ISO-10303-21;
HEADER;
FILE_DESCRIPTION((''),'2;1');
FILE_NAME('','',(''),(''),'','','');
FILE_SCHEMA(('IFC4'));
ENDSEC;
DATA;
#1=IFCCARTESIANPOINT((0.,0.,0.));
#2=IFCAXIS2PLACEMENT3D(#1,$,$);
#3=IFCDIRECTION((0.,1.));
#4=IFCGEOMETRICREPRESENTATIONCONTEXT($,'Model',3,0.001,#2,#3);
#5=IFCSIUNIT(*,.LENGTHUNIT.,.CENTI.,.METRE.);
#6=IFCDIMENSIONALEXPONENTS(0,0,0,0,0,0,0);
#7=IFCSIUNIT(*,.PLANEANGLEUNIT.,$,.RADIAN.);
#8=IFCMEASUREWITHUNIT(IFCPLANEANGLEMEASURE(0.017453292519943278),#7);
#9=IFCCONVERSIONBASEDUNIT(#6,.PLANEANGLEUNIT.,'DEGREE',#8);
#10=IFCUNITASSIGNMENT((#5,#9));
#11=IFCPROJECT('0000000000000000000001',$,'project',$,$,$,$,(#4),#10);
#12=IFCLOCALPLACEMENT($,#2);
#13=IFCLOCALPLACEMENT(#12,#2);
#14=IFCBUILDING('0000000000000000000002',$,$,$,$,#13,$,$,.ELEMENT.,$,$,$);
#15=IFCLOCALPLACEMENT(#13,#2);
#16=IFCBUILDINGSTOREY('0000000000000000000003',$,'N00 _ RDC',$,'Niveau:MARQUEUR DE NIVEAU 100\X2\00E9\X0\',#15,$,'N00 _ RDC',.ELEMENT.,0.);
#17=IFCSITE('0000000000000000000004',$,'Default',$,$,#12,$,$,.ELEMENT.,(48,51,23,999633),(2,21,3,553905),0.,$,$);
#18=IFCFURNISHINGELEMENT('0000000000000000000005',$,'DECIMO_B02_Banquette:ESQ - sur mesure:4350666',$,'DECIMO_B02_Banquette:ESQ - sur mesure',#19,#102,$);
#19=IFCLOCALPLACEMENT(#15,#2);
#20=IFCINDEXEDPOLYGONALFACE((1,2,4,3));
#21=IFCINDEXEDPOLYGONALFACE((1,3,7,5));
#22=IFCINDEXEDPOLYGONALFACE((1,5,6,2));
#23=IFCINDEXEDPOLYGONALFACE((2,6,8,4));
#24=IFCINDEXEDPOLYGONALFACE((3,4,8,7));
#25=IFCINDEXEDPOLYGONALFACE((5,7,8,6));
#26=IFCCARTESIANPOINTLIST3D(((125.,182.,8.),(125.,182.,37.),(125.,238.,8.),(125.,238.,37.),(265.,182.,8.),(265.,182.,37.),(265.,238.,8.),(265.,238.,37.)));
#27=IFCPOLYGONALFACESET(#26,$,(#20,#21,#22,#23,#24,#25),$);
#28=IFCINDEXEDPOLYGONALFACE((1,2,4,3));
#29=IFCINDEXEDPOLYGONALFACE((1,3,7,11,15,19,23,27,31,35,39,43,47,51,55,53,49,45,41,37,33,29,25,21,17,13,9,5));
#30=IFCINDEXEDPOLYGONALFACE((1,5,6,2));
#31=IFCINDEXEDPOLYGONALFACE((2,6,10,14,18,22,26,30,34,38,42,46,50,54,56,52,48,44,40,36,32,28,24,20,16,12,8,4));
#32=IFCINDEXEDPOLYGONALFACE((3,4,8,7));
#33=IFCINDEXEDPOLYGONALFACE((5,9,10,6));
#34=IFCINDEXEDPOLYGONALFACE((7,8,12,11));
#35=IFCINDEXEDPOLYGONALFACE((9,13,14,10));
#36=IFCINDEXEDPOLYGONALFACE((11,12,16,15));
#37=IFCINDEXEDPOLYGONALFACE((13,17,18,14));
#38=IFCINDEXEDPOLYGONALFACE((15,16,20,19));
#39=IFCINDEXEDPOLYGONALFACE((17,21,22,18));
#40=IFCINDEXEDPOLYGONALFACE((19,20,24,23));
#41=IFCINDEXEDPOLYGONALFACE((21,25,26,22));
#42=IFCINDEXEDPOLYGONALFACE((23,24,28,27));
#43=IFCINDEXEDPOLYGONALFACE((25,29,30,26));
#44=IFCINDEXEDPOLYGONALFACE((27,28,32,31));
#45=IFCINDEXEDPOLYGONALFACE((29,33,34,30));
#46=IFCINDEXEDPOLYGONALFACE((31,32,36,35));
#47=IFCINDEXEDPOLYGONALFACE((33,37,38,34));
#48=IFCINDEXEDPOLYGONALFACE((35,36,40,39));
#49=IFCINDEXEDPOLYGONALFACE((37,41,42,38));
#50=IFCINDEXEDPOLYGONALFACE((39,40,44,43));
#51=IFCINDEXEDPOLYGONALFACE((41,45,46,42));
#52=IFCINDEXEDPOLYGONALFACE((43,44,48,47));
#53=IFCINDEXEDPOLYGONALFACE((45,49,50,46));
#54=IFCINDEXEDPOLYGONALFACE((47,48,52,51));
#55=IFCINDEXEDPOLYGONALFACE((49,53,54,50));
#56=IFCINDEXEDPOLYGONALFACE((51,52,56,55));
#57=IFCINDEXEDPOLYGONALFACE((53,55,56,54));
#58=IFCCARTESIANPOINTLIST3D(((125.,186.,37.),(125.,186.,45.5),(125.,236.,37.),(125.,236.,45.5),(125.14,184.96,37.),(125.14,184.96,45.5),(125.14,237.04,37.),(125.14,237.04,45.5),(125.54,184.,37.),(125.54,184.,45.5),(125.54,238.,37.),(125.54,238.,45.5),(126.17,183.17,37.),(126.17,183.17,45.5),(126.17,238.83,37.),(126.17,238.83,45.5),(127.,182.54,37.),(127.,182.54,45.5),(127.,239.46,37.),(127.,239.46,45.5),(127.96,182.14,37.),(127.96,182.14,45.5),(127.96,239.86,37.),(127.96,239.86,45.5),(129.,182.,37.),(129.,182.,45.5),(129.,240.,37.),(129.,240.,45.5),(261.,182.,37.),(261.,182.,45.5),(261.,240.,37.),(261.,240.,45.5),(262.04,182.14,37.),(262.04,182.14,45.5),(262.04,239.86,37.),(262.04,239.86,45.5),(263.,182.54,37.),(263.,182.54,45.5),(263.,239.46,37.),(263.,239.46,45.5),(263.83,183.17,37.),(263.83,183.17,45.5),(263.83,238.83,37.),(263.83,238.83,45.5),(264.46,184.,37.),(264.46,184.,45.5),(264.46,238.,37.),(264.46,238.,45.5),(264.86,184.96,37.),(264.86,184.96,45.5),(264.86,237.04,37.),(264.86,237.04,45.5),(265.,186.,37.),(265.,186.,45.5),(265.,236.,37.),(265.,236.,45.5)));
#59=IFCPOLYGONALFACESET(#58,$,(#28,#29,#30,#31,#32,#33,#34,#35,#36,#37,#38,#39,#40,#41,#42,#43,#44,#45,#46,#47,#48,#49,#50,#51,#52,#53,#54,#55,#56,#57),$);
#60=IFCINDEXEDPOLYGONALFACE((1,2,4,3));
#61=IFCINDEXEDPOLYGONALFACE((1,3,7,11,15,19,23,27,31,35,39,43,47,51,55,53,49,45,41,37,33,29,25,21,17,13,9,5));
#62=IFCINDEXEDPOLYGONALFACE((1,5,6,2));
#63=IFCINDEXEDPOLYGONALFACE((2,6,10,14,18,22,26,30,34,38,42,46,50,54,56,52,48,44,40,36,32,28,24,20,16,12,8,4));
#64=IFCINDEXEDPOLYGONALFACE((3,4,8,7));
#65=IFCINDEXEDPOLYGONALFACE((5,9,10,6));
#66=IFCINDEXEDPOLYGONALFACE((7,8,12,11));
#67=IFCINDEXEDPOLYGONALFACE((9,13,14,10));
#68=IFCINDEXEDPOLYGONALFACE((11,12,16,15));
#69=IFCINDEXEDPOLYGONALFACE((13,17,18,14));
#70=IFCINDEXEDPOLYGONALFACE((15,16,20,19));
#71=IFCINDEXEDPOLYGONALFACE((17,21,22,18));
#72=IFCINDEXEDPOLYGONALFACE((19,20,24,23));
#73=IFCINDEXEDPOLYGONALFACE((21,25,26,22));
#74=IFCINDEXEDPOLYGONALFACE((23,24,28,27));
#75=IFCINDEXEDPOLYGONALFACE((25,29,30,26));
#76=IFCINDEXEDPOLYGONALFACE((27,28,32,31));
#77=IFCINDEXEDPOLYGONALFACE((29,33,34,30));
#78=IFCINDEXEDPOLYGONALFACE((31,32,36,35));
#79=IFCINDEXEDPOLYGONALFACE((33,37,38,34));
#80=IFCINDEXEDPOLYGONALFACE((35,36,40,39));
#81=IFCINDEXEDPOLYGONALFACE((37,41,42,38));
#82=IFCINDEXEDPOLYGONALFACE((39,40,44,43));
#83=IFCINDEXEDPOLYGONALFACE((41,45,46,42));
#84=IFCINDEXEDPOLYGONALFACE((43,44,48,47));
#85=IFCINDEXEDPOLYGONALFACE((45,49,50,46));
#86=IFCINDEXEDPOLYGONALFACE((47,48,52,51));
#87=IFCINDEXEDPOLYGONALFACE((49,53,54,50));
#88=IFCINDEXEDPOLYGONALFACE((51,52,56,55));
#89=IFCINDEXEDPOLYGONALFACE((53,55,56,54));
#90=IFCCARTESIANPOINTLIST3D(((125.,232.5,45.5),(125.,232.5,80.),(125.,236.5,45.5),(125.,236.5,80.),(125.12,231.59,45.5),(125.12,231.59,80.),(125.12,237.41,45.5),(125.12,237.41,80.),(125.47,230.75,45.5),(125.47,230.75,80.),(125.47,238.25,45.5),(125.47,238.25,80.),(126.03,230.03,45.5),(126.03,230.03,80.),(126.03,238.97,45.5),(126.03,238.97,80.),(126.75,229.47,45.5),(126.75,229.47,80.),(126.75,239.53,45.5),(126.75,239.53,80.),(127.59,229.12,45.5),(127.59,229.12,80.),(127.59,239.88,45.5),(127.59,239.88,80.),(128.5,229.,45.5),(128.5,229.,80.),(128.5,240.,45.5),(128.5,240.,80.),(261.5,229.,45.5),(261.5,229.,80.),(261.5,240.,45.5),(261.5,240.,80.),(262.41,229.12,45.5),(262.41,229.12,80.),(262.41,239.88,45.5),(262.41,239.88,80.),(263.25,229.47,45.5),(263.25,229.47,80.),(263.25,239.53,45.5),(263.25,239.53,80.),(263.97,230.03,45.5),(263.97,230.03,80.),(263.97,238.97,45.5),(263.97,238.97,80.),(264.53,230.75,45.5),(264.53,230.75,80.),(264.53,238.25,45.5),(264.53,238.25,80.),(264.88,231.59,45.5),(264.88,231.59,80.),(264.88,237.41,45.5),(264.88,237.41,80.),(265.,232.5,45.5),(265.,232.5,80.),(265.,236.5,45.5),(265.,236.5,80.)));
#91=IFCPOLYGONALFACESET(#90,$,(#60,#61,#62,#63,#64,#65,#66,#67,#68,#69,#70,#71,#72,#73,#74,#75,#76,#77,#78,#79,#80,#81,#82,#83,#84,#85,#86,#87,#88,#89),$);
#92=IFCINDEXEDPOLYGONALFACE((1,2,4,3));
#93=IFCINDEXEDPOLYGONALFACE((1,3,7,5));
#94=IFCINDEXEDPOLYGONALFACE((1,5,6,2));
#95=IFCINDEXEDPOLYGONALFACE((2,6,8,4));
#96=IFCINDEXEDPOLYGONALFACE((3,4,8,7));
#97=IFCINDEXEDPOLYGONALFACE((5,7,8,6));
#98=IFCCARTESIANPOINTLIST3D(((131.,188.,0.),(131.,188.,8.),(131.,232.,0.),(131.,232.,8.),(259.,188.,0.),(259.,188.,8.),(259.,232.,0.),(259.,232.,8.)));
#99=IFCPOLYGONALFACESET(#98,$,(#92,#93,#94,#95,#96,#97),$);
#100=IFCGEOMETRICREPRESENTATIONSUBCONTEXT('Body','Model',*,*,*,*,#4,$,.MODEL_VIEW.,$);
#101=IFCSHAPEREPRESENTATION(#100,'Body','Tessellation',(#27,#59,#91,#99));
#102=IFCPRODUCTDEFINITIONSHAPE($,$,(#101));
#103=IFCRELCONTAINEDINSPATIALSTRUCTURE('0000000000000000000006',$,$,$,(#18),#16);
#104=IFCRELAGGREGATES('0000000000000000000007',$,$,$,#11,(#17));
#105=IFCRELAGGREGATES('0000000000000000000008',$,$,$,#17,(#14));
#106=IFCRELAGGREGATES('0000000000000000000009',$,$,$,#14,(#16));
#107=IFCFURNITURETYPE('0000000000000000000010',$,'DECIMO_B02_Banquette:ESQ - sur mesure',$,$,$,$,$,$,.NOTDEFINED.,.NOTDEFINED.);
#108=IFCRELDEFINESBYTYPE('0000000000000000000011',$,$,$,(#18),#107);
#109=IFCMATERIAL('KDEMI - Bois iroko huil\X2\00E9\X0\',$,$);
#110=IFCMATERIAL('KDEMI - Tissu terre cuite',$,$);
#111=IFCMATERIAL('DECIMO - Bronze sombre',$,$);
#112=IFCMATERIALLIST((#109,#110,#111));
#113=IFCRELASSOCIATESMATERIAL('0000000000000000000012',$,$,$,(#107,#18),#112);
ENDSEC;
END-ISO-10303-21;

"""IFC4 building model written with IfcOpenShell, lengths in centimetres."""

from ifc_helpers import new_model, entity, si_unit, converted_unit, direction, frame, frame_2d, origin, origin_2d_with_axis, place, context, subcontext, project, spatial, polyline, circle_curve, parameter, trimmed, segment, composite_curve, rectangle, outline, extrude, source, transform, mapped, material, material_list, type_object, type_shapes, element, save


model = new_model("IFC4")

# Units and contexts
model_context = context("Model", 3, precision=0.001, world=origin(), true_north=direction((0.0, 1.0)))
body_context = subcontext(model_context, "Body", "Model", "MODEL_VIEW")
ifc_project = project(units=[si_unit("LENGTHUNIT", "METRE", prefix="CENTI"), converted_unit("PLANEANGLEUNIT", "DEGREE", entity("IfcPlaneAngleMeasure", 0.017453292519943278), si_unit("PLANEANGLEUNIT", "RADIAN"), dimensions=[0, 0, 0, 0, 0, 0, 0])], contexts=[model_context])

# Site, building, storey
site_placement = place(None, origin())
site = spatial("IfcSite", under=ifc_project, at=site_placement, Name="Default", CompositionType="ELEMENT", RefLatitude=(48, 51, 23, 999633), RefLongitude=(2, 21, 3, 553905), RefElevation=0.0)
building_placement = place(site_placement, origin())
building = spatial("IfcBuilding", under=site, at=building_placement, CompositionType="ELEMENT")
storey_placement = place(building_placement, origin())
storey = spatial("IfcBuildingStorey", under=building, at=storey_placement, Name="N00 _ RDC", ObjectType="Niveau:MARQUEUR DE NIVEAU 100é", LongName="N00 _ RDC", CompositionType="ELEMENT", Elevation=0.0)

# Furnishing element
ifc_material_1 = material(Name="KDEMI - Tissu terre cuite")
ifc_material_2 = material(Name="KDEMI - Bois iroko huilé")
ifc_material_3 = material(Name="DECIMO - Bronze sombre")
ifc_material_list_1 = material_list([ifc_material_2, ifc_material_1, ifc_material_3])
furniture_type_1 = type_object("IfcFurnitureType", Name="DECIMO_B02_Banquette:ESQ - sur mesure", AssemblyPlace="NOTDEFINED", material=ifc_material_list_1)
shared_shape_1 = source(origin(), body_context, "Body", "SweptSolid", [
    extrude(rectangle(XDim=140.0, YDim=56.0, at=origin_2d_with_axis()), frame((70.0, 28.0, 8.0)), (0.0, 0.0, 1.0), 29.0),
    extrude(outline(composite_curve([segment(polyline([(-66.0, -29.0), (66.0, -29.0)]), True, "CONTINUOUS"), segment(trimmed(circle_curve(frame_2d((66.0, -25.0), x_axis=(1.0, 0.0)), 4.0), [parameter(270.0)], [parameter(0.0)], True, "PARAMETER"), True, "CONTINUOUS"), segment(polyline([(70.0, -25.0), (70.0, 25.0)]), True, "CONTINUOUS"), segment(trimmed(circle_curve(frame_2d((66.0, 25.0), x_axis=(1.0, 0.0)), 4.0), [parameter(0.0)], [parameter(90.0)], True, "PARAMETER"), True, "CONTINUOUS"), segment(polyline([(66.0, 29.0), (-66.0, 29.0)]), True, "CONTINUOUS"), segment(trimmed(circle_curve(frame_2d((-66.0, 25.0), x_axis=(1.0, 0.0)), 4.0), [parameter(90.0)], [parameter(180.0)], True, "PARAMETER"), True, "CONTINUOUS"), segment(polyline([(-70.0, 25.0), (-70.0, -25.0)]), True, "CONTINUOUS"), segment(trimmed(circle_curve(frame_2d((-66.0, -25.0), x_axis=(1.0, 0.0)), 4.0), [parameter(180.0)], [parameter(270.0)], True, "PARAMETER"), True, "CONTINUOUS")], self_intersect=False)), frame((70.0, 29.0, 37.0)), (0.0, 0.0, 1.0), 8.5),
    extrude(outline(composite_curve([segment(polyline([(-66.5, -5.5), (66.5, -5.5)]), True, "CONTINUOUS"), segment(trimmed(circle_curve(frame_2d((66.5, -2.0), x_axis=(1.0, 0.0)), 3.5), [parameter(270.0)], [parameter(0.0)], True, "PARAMETER"), True, "CONTINUOUS"), segment(polyline([(70.0, -2.0), (70.0, 2.0)]), True, "CONTINUOUS"), segment(trimmed(circle_curve(frame_2d((66.5, 2.0), x_axis=(1.0, 0.0)), 3.5), [parameter(0.0)], [parameter(90.0)], True, "PARAMETER"), True, "CONTINUOUS"), segment(polyline([(66.5, 5.5), (-66.5, 5.5)]), True, "CONTINUOUS"), segment(trimmed(circle_curve(frame_2d((-66.5, 2.0), x_axis=(1.0, 0.0)), 3.5), [parameter(90.0)], [parameter(180.0)], True, "PARAMETER"), True, "CONTINUOUS"), segment(polyline([(-70.0, 2.0), (-70.0, -2.0)]), True, "CONTINUOUS"), segment(trimmed(circle_curve(frame_2d((-66.5, -2.0), x_axis=(1.0, 0.0)), 3.5), [parameter(180.0)], [parameter(270.0)], True, "PARAMETER"), True, "CONTINUOUS")], self_intersect=False)), frame((70.0, 52.5, 45.5)), (0.0, 0.0, 1.0), 34.5),
    extrude(rectangle(XDim=128.0, YDim=44.0, at=frame_2d((0.0, 0.0), x_axis=(1.0, 0.0))), frame((70.0, 28.0, 0.0)), (0.0, 0.0, 1.0), 8.0),
])
type_shapes(furniture_type_1, [shared_shape_1])
furnishing_1_placement = place(storey_placement, frame((125.0, 182.0, 0.0)))
element("IfcFurnishingElement", 1, at=furnishing_1_placement, inside=storey, type_object=furniture_type_1, material=ifc_material_list_1, Name="DECIMO_B02_Banquette:ESQ - sur mesure:4350666", ObjectType="DECIMO_B02_Banquette:ESQ - sur mesure", context=body_context, shape_type="MappedRepresentation", body=[
    mapped(shared_shape_1, transform((0.0, 0.0, 0.0), scale=1.0)),
])

save(model, "model.ifc")
